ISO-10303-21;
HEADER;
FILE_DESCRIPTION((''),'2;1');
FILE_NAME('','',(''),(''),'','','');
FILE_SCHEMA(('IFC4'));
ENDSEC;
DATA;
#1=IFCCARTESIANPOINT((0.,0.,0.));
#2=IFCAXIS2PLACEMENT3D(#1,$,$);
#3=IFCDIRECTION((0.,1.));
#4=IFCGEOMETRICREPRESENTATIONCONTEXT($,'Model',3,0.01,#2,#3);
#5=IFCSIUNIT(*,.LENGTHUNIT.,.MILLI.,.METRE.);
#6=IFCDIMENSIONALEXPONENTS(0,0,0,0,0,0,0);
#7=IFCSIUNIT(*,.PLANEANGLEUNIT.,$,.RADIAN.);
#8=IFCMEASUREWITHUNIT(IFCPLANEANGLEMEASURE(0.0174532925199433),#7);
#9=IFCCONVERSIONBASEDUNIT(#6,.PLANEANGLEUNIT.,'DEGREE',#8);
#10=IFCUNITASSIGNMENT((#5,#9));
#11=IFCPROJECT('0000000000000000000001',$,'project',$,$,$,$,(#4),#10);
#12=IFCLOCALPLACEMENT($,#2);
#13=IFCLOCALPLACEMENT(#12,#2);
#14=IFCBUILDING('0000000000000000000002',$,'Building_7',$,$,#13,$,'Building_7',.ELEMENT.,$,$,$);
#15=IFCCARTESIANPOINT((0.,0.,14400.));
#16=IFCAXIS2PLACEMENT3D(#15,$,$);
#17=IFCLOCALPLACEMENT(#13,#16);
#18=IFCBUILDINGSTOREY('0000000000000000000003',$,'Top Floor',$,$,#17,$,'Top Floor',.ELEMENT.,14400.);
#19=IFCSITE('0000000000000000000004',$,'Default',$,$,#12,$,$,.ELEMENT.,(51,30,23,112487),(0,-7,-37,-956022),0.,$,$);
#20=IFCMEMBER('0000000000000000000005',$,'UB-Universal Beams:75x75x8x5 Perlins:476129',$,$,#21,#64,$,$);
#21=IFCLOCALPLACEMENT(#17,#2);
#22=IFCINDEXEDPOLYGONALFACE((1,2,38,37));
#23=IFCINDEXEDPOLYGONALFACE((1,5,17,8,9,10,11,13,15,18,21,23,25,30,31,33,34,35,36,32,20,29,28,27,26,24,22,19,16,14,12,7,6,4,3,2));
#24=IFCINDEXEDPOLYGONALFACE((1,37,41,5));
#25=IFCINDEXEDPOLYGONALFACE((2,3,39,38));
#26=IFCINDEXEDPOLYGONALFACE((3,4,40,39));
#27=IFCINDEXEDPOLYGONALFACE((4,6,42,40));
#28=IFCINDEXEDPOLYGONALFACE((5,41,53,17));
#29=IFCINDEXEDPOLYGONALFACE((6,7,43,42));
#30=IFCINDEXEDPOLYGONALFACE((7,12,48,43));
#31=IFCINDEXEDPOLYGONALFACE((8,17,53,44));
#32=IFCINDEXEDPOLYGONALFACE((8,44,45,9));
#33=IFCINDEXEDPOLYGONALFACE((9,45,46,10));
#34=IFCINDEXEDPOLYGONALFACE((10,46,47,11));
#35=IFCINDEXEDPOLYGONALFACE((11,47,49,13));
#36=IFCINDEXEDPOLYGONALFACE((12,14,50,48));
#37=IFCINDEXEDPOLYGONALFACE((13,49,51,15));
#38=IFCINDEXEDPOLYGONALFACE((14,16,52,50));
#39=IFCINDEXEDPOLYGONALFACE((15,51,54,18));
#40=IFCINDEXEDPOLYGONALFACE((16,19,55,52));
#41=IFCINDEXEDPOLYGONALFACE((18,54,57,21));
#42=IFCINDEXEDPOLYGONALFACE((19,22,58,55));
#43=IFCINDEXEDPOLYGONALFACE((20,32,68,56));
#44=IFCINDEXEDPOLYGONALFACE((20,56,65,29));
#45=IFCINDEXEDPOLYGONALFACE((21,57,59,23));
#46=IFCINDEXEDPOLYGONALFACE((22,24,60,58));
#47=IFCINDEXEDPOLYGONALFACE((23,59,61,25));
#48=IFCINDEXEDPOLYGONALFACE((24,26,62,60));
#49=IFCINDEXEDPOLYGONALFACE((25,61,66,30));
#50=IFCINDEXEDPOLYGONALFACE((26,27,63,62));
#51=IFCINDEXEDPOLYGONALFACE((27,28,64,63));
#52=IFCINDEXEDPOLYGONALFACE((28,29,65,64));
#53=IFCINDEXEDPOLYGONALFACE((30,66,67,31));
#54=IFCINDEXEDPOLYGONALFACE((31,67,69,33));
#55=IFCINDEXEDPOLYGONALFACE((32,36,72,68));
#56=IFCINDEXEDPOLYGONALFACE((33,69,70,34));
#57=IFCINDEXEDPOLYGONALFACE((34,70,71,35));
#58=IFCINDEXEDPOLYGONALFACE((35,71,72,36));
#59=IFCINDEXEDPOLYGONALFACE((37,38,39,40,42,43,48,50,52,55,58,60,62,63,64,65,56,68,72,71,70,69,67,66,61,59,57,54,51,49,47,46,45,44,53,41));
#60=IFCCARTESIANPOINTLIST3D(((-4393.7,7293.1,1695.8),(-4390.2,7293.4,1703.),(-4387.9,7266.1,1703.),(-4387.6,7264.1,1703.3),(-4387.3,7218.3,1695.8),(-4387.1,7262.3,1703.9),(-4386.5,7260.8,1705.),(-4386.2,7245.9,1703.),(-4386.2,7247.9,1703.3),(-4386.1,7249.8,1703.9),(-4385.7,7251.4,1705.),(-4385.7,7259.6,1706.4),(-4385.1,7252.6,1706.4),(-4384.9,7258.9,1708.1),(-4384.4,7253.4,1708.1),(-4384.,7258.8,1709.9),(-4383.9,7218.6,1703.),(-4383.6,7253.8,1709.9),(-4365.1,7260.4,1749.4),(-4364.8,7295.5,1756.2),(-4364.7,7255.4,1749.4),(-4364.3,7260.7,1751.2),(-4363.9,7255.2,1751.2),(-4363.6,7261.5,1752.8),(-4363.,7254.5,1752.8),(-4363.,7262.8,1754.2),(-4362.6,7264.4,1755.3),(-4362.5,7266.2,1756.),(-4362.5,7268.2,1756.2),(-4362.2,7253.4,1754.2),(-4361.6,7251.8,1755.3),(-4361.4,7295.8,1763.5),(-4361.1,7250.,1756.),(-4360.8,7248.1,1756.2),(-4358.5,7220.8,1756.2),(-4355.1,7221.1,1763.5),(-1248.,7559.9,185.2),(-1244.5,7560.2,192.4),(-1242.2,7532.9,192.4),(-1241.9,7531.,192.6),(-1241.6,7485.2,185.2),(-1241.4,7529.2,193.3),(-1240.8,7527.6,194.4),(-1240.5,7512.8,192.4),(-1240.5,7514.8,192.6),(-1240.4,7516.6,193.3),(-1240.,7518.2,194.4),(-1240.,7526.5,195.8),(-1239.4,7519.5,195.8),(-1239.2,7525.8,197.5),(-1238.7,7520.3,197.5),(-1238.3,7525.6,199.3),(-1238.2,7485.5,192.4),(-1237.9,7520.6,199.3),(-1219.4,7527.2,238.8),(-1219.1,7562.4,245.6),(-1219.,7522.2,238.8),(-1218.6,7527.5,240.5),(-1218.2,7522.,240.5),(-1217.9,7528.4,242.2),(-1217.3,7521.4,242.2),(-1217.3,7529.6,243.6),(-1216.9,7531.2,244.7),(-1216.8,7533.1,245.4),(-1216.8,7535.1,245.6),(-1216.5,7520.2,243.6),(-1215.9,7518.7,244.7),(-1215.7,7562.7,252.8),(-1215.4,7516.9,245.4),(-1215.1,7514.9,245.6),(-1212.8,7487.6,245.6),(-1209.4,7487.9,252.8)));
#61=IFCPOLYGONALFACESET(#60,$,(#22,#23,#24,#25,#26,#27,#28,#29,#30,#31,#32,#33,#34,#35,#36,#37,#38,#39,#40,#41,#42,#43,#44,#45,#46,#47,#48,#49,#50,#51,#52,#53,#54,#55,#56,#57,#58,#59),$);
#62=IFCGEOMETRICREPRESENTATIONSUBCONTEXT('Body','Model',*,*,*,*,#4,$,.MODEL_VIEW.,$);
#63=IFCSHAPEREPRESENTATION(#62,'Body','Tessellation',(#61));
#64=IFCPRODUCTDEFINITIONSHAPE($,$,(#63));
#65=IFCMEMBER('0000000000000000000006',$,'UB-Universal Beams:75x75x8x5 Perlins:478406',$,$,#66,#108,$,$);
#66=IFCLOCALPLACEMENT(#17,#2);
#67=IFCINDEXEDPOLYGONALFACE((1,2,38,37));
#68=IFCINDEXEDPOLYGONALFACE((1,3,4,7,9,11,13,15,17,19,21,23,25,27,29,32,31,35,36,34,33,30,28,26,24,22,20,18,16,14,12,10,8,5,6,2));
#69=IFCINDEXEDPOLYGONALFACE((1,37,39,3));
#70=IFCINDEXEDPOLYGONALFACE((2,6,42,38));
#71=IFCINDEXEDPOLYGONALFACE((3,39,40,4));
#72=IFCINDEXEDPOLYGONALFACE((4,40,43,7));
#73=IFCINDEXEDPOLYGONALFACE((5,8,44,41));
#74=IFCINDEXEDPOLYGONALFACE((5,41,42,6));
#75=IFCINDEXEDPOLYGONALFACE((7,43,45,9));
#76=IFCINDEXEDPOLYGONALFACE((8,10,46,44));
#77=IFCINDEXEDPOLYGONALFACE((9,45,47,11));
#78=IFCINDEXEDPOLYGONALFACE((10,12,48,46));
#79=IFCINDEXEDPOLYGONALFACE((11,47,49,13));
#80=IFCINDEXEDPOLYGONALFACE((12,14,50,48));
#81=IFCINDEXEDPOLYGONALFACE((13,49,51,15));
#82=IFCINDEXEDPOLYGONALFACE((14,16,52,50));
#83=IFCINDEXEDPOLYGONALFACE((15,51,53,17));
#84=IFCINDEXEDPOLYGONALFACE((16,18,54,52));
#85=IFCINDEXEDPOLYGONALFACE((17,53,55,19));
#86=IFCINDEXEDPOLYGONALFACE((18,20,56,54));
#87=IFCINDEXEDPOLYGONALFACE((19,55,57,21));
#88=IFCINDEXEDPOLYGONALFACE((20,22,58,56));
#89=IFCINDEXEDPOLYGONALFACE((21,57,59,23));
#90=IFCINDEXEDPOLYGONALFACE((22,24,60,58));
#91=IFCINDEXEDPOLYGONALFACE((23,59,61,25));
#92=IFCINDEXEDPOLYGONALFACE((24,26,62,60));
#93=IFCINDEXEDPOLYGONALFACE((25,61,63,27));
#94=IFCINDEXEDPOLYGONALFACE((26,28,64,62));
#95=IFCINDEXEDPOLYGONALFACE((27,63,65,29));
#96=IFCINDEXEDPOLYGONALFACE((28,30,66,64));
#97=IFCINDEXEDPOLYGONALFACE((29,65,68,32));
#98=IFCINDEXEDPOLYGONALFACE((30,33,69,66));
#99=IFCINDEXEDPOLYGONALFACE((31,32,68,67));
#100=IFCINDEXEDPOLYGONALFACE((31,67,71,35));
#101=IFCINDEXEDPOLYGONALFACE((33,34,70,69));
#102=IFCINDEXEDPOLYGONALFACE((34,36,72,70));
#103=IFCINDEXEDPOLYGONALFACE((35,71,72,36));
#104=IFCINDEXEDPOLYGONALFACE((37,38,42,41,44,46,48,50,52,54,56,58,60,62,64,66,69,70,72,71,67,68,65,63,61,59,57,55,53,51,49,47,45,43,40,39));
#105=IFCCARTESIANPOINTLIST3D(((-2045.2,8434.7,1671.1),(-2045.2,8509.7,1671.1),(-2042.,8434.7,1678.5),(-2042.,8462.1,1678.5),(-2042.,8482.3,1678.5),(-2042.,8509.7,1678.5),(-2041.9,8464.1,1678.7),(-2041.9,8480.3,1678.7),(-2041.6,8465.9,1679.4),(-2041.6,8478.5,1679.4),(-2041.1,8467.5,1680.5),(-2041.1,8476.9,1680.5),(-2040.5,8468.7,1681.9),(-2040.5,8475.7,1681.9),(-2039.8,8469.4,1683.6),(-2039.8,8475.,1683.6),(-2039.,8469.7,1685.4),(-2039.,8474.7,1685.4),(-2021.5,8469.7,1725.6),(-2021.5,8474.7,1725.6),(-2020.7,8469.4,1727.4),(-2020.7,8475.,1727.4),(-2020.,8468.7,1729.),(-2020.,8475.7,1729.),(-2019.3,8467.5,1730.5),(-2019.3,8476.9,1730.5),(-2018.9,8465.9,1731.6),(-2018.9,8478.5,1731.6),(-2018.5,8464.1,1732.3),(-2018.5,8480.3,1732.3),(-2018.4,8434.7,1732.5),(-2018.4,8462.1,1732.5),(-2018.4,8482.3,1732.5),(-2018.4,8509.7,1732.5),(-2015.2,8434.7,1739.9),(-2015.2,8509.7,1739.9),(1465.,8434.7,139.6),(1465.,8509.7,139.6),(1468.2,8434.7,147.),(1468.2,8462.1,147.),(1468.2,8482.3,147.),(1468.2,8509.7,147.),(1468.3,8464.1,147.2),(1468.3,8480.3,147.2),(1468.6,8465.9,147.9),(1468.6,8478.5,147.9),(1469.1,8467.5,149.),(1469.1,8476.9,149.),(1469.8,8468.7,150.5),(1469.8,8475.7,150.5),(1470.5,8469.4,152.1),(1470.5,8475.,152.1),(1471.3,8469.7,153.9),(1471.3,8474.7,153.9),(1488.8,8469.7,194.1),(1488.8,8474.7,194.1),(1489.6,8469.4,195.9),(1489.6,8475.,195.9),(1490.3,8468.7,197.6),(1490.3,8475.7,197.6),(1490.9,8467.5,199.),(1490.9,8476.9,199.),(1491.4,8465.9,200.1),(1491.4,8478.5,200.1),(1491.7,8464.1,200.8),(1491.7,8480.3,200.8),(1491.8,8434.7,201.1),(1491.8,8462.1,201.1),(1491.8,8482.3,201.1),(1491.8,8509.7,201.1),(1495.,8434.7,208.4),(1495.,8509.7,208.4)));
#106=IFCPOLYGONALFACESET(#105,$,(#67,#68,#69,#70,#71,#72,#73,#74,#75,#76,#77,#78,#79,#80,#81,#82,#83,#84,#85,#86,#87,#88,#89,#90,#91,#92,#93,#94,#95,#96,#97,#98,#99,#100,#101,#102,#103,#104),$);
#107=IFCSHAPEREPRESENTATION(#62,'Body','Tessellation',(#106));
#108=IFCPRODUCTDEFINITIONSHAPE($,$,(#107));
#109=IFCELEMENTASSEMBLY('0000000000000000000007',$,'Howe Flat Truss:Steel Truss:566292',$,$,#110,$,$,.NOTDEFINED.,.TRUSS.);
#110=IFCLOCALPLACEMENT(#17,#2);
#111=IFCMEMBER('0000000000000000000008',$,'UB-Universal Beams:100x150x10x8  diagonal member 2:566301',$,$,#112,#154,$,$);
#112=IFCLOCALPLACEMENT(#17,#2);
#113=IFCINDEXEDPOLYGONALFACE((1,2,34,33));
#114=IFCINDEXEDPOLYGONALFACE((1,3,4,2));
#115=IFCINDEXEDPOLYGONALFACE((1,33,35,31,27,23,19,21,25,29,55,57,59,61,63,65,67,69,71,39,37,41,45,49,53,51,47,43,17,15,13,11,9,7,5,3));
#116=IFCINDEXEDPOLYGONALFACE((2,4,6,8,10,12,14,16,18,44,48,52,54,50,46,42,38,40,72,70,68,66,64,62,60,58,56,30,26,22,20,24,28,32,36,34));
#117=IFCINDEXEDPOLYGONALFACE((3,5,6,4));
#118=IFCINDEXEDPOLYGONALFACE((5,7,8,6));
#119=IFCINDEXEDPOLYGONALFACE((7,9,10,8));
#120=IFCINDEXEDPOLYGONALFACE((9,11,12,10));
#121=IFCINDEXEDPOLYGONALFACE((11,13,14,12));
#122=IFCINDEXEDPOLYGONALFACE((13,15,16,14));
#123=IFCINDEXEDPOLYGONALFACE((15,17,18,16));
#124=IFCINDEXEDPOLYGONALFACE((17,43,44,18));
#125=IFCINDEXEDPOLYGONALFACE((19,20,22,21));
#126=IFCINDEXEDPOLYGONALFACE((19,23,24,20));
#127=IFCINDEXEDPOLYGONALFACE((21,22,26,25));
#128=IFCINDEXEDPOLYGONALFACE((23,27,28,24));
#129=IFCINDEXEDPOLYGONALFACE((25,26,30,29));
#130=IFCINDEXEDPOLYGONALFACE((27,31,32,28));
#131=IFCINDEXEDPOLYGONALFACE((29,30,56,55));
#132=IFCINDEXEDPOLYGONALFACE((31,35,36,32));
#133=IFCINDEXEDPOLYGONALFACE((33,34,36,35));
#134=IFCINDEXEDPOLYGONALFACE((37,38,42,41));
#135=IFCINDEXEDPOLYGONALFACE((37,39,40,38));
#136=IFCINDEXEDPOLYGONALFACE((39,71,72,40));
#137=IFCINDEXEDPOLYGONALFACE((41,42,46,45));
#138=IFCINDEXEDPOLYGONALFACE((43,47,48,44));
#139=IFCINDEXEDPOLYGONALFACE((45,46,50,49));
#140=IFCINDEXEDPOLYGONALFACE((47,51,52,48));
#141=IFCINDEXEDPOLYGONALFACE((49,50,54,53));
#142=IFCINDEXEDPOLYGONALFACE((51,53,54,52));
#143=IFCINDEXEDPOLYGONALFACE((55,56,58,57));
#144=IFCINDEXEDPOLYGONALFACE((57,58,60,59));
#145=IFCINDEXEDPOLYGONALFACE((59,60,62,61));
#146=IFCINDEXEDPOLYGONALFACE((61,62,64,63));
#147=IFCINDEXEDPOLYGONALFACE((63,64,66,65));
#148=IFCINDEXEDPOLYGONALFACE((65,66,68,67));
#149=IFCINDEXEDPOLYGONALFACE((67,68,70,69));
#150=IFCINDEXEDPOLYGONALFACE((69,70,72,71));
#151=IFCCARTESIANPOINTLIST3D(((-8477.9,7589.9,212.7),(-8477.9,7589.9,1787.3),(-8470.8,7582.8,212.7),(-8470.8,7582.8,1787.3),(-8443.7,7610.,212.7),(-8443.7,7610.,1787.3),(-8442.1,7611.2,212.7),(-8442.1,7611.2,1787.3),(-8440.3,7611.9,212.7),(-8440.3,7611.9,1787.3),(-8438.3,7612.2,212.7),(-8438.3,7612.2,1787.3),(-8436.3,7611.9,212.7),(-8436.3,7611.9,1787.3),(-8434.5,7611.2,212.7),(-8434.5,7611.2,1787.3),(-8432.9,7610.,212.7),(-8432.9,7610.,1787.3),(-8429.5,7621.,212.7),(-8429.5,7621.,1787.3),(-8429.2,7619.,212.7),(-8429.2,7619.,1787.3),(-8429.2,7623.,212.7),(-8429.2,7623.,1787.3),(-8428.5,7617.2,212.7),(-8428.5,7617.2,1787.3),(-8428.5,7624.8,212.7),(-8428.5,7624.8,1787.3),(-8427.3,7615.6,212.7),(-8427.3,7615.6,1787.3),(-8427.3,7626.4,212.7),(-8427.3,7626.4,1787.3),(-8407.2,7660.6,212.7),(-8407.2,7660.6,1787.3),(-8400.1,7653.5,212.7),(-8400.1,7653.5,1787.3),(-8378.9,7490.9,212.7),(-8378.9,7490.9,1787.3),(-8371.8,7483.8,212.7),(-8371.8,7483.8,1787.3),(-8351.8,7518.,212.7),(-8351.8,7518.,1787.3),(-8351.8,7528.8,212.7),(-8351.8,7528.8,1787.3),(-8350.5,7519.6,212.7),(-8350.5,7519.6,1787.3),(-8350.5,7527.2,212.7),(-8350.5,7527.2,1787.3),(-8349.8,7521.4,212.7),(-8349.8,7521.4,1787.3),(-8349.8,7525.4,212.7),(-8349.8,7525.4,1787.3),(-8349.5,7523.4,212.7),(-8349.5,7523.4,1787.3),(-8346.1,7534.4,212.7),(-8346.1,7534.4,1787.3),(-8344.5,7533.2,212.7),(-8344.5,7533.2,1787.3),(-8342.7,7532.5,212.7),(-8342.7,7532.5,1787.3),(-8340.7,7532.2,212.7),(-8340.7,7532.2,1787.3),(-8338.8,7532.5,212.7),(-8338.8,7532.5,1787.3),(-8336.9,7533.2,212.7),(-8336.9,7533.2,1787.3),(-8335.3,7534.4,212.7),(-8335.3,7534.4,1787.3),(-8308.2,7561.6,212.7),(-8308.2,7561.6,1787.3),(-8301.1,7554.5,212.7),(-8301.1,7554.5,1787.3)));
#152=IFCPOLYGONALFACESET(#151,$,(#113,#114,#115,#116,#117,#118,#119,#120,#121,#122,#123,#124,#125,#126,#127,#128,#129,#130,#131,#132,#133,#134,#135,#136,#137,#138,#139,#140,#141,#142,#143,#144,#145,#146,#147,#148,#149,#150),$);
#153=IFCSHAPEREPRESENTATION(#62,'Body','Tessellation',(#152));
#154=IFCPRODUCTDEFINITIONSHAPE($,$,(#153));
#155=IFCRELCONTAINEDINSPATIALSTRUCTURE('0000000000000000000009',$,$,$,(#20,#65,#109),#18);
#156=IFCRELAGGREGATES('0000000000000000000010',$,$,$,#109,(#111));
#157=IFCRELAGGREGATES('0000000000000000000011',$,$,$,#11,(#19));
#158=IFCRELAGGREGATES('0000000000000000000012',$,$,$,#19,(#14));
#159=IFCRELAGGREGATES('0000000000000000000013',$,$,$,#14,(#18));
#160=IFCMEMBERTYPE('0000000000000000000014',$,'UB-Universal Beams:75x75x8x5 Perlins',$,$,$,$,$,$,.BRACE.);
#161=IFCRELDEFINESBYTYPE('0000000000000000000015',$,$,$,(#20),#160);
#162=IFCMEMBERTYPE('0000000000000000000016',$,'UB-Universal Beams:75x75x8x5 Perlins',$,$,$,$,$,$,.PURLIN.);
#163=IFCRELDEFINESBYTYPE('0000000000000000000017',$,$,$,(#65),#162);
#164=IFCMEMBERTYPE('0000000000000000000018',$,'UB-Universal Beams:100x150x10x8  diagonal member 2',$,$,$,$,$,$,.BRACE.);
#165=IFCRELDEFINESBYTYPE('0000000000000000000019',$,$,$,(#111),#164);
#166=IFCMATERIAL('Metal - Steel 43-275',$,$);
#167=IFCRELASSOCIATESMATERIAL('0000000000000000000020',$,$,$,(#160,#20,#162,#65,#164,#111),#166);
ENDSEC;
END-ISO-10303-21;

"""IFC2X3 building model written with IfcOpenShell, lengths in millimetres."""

from ifc_helpers import new_model, entity, si_unit, converted_unit, direction, frame, frame_2d, origin, place, context, subcontext, project, spatial, polyline, circle_curve, parameter, trimmed, segment, composite_curve, outline, extrude, source, transform, mapped, material, type_object, type_shapes, element, aggregate, save


model = new_model("IFC2X3")

# Units and contexts
model_context = context("Model", 3, precision=0.01, world=origin(), true_north=direction((0.0, 1.0)))
body_context = subcontext(model_context, "Body", "Model", "MODEL_VIEW")
ifc_project = project(units=[si_unit("LENGTHUNIT", "METRE", prefix="MILLI"), converted_unit("PLANEANGLEUNIT", "DEGREE", entity("IfcPlaneAngleMeasure", 0.0174532925199433), si_unit("PLANEANGLEUNIT", "RADIAN"), dimensions=[0, 0, 0, 0, 0, 0, 0])], contexts=[model_context])

# Site, building, storey
site_placement = place(None, origin())
site = spatial("IfcSite", under=ifc_project, at=site_placement, Name="Default", CompositionType="ELEMENT", RefLatitude=(51, 30, 23, 112487), RefLongitude=(0, -7, -37, -956022), RefElevation=0.0)
building_placement = place(site_placement, origin())
building = spatial("IfcBuilding", under=site, at=building_placement, Name="Building_7", LongName="Building_7", CompositionType="ELEMENT")
storey_placement = place(building_placement, frame((0.0, 0.0, 14400.0)))
storey = spatial("IfcBuildingStorey", under=building, at=storey_placement, Name="Top Floor", LongName="Top Floor", CompositionType="ELEMENT", Elevation=14400.0)

# Members
ifc_material = material(Name="Metal - Steel 43-275")
member_type_1 = type_object("IfcMemberType", Name="UB-Universal Beams:75x75x8x5 Perlins", PredefinedType="BRACE", material=ifc_material)
shared_shape_1 = source(origin(), body_context, "Body", "SweptSolid", [
    extrude(outline(composite_curve([segment(polyline([(-37.5, -29.5), (-37.5, -37.5)]), True, "CONTINUOUS"), segment(polyline([(-37.5, -37.5), (37.5, -37.5)]), True, "CONTINUOUS"), segment(polyline([(37.5, -37.5), (37.5, -29.5)]), True, "CONTINUOUS"), segment(polyline([(37.5, -29.5), (10.1, -29.5)]), True, "CONTINUOUS"), segment(trimmed(circle_curve(frame_2d((10.1, -21.9), x_axis=(1.0, 0.0)), 7.6), [parameter(180.0)], [parameter(270.0)], True, "PARAMETER"), False, "CONTINUOUS"), segment(polyline([(2.5, -21.9), (2.5, 21.9)]), True, "CONTINUOUS"), segment(trimmed(circle_curve(frame_2d((10.1, 21.9), x_axis=(1.0, 0.0)), 7.6), [parameter(90.0)], [parameter(180.0)], True, "PARAMETER"), False, "CONTINUOUS"), segment(polyline([(10.1, 29.5), (37.5, 29.5)]), True, "CONTINUOUS"), segment(polyline([(37.5, 29.5), (37.5, 37.5)]), True, "CONTINUOUS"), segment(polyline([(37.5, 37.5), (-37.5, 37.5)]), True, "CONTINUOUS"), segment(polyline([(-37.5, 37.5), (-37.5, 29.5)]), True, "CONTINUOUS"), segment(polyline([(-37.5, 29.5), (-10.1, 29.5)]), True, "CONTINUOUS"), segment(trimmed(circle_curve(frame_2d((-10.1, 21.9), x_axis=(1.0, 0.0)), 7.6), [parameter(360.0)], [parameter(90.0)], True, "PARAMETER"), False, "CONTINUOUS"), segment(polyline([(-2.5, 21.9), (-2.5, -21.9)]), True, "CONTINUOUS"), segment(trimmed(circle_curve(frame_2d((-10.1, -21.9), x_axis=(1.0, 0.0)), 7.6), [parameter(270.0)], [parameter(360.0)], True, "PARAMETER"), False, "CONTINUOUS"), segment(polyline([(-10.1, -29.5), (-37.5, -29.5)]), True, "CONTINUOUS")], self_intersect=False)), frame((-1761.0, 0.0, 0.0), z_axis=(-1.0, 0.0, 0.0), x_axis=(0.0, -1.0, 0.0)), (0.0, 0.0, -1.0), 3499.8),
])
type_shapes(member_type_1, [shared_shape_1])
member_1_placement = place(storey_placement, frame((-2811.4, 7389.7, 979.1), z_axis=(0.430084, 0.036485, 0.902052), x_axis=(-0.898823, -0.076249, 0.431628)))
element("IfcMember", 1, at=member_1_placement, inside=storey, type_object=member_type_1, material=ifc_material, Name="UB-Universal Beams:75x75x8x5 Perlins:476129", context=body_context, shape_type="MappedRepresentation", body=[
    mapped(shared_shape_1, transform((0.0, 0.0, 0.0), scale=1.0)),
])
member_type_2 = type_object("IfcMemberType", Name="UB-Universal Beams:75x75x8x5 Perlins", PredefinedType="PURLIN", material=ifc_material)
shared_shape_2 = source(origin(), body_context, "Body", "SweptSolid", [
    extrude(outline(composite_curve([segment(polyline([(-37.5, -29.5), (-37.5, -37.5)]), True, "CONTINUOUS"), segment(polyline([(-37.5, -37.5), (37.5, -37.5)]), True, "CONTINUOUS"), segment(polyline([(37.5, -37.5), (37.5, -29.5)]), True, "CONTINUOUS"), segment(polyline([(37.5, -29.5), (10.1, -29.5)]), True, "CONTINUOUS"), segment(trimmed(circle_curve(frame_2d((10.1, -21.9), x_axis=(1.0, 0.0)), 7.6), [parameter(180.0)], [parameter(270.0)], True, "PARAMETER"), False, "CONTINUOUS"), segment(polyline([(2.5, -21.9), (2.5, 21.9)]), True, "CONTINUOUS"), segment(trimmed(circle_curve(frame_2d((10.1, 21.9), x_axis=(1.0, 0.0)), 7.6), [parameter(90.0)], [parameter(180.0)], True, "PARAMETER"), False, "CONTINUOUS"), segment(polyline([(10.1, 29.5), (37.5, 29.5)]), True, "CONTINUOUS"), segment(polyline([(37.5, 29.5), (37.5, 37.5)]), True, "CONTINUOUS"), segment(polyline([(37.5, 37.5), (-37.5, 37.5)]), True, "CONTINUOUS"), segment(polyline([(-37.5, 37.5), (-37.5, 29.5)]), True, "CONTINUOUS"), segment(polyline([(-37.5, 29.5), (-10.1, 29.5)]), True, "CONTINUOUS"), segment(trimmed(circle_curve(frame_2d((-10.1, 21.9), x_axis=(1.0, 0.0)), 7.6), [parameter(360.0)], [parameter(90.0)], True, "PARAMETER"), False, "CONTINUOUS"), segment(polyline([(-2.5, 21.9), (-2.5, -21.9)]), True, "CONTINUOUS"), segment(trimmed(circle_curve(frame_2d((-10.1, -21.9), x_axis=(1.0, 0.0)), 7.6), [parameter(270.0)], [parameter(360.0)], True, "PARAMETER"), False, "CONTINUOUS"), segment(polyline([(-10.1, -29.5), (-37.5, -29.5)]), True, "CONTINUOUS")], self_intersect=False)), frame((-1984.6, 0.0, 0.0), z_axis=(-1.0, 0.0, 0.0), x_axis=(0.0, -1.0, 0.0)), (0.0, 0.0, -1.0), 3829.8),
])
type_shapes(member_type_2, [shared_shape_2])
member_2_placement = place(storey_placement, frame((-339.0, 8472.2, 967.6), z_axis=(0.399883, 0.0, 0.916566), x_axis=(-0.916566, 0.0, 0.399883)))
element("IfcMember", 2, at=member_2_placement, inside=storey, type_object=member_type_2, material=ifc_material, Name="UB-Universal Beams:75x75x8x5 Perlins:478406", context=body_context, shape_type="MappedRepresentation", body=[
    mapped(shared_shape_2, transform((0.0, 0.0, 0.0), scale=1.0)),
])

# Element assembly, member
assembly_1_placement = place(storey_placement, origin())
assembly_1 = element("IfcElementAssembly", 3, at=assembly_1_placement, inside=storey, Name="Howe Flat Truss:Steel Truss:566292", AssemblyPlace="NOTDEFINED", PredefinedType="TRUSS")
member_type_3 = type_object("IfcMemberType", Name="UB-Universal Beams:100x150x10x8  diagonal member 2", PredefinedType="BRACE", material=ifc_material)
shared_shape_3 = source(origin(), body_context, "Body", "SweptSolid", [
    extrude(outline(composite_curve([segment(polyline([(-50.0, -65.0), (-50.0, -75.0)]), True, "CONTINUOUS"), segment(polyline([(-50.0, -75.0), (50.0, -75.0)]), True, "CONTINUOUS"), segment(polyline([(50.0, -75.0), (50.0, -65.0)]), True, "CONTINUOUS"), segment(polyline([(50.0, -65.0), (11.6, -65.0)]), True, "CONTINUOUS"), segment(trimmed(circle_curve(frame_2d((11.6, -57.4), x_axis=(1.0, 0.0)), 7.6), [parameter(180.0)], [parameter(270.0)], True, "PARAMETER"), False, "CONTINUOUS"), segment(polyline([(4.0, -57.4), (4.0, 57.4)]), True, "CONTINUOUS"), segment(trimmed(circle_curve(frame_2d((11.6, 57.4), x_axis=(1.0, 0.0)), 7.6), [parameter(90.0)], [parameter(180.0)], True, "PARAMETER"), False, "CONTINUOUS"), segment(polyline([(11.6, 65.0), (50.0, 65.0)]), True, "CONTINUOUS"), segment(polyline([(50.0, 65.0), (50.0, 75.0)]), True, "CONTINUOUS"), segment(polyline([(50.0, 75.0), (-50.0, 75.0)]), True, "CONTINUOUS"), segment(polyline([(-50.0, 75.0), (-50.0, 65.0)]), True, "CONTINUOUS"), segment(polyline([(-50.0, 65.0), (-11.6, 65.0)]), True, "CONTINUOUS"), segment(trimmed(circle_curve(frame_2d((-11.6, 57.4), x_axis=(1.0, 0.0)), 7.6), [parameter(360.0)], [parameter(90.0)], True, "PARAMETER"), False, "CONTINUOUS"), segment(polyline([(-4.0, 57.4), (-4.0, -57.4)]), True, "CONTINUOUS"), segment(trimmed(circle_curve(frame_2d((-11.6, -57.4), x_axis=(1.0, 0.0)), 7.6), [parameter(270.0)], [parameter(360.0)], True, "PARAMETER"), False, "CONTINUOUS"), segment(polyline([(-11.6, -65.0), (-50.0, -65.0)]), True, "CONTINUOUS")], self_intersect=False)), frame((-787.3, 0.0, 0.0), z_axis=(-1.0, 0.0, 0.0), x_axis=(0.0, -1.0, 0.0)), (0.0, 0.0, -1.0), 1574.6),
])
type_shapes(member_type_3, [shared_shape_3])
member_3_placement = place(assembly_1_placement, frame((-8389.5, 7572.2, 1000.0), z_axis=(-0.707107, 0.707107, 0.0), x_axis=(0.0, 0.0, 1.0)))
member_3 = element("IfcMember", 4, at=member_3_placement, type_object=member_type_3, material=ifc_material, Name="UB-Universal Beams:100x150x10x8  diagonal member 2:566301", context=body_context, shape_type="MappedRepresentation", body=[
    mapped(shared_shape_3, transform((0.0, 0.0, 0.0), scale=1.0)),
])

aggregate(assembly_1, [member_3])

save(model, "model.ifc")
